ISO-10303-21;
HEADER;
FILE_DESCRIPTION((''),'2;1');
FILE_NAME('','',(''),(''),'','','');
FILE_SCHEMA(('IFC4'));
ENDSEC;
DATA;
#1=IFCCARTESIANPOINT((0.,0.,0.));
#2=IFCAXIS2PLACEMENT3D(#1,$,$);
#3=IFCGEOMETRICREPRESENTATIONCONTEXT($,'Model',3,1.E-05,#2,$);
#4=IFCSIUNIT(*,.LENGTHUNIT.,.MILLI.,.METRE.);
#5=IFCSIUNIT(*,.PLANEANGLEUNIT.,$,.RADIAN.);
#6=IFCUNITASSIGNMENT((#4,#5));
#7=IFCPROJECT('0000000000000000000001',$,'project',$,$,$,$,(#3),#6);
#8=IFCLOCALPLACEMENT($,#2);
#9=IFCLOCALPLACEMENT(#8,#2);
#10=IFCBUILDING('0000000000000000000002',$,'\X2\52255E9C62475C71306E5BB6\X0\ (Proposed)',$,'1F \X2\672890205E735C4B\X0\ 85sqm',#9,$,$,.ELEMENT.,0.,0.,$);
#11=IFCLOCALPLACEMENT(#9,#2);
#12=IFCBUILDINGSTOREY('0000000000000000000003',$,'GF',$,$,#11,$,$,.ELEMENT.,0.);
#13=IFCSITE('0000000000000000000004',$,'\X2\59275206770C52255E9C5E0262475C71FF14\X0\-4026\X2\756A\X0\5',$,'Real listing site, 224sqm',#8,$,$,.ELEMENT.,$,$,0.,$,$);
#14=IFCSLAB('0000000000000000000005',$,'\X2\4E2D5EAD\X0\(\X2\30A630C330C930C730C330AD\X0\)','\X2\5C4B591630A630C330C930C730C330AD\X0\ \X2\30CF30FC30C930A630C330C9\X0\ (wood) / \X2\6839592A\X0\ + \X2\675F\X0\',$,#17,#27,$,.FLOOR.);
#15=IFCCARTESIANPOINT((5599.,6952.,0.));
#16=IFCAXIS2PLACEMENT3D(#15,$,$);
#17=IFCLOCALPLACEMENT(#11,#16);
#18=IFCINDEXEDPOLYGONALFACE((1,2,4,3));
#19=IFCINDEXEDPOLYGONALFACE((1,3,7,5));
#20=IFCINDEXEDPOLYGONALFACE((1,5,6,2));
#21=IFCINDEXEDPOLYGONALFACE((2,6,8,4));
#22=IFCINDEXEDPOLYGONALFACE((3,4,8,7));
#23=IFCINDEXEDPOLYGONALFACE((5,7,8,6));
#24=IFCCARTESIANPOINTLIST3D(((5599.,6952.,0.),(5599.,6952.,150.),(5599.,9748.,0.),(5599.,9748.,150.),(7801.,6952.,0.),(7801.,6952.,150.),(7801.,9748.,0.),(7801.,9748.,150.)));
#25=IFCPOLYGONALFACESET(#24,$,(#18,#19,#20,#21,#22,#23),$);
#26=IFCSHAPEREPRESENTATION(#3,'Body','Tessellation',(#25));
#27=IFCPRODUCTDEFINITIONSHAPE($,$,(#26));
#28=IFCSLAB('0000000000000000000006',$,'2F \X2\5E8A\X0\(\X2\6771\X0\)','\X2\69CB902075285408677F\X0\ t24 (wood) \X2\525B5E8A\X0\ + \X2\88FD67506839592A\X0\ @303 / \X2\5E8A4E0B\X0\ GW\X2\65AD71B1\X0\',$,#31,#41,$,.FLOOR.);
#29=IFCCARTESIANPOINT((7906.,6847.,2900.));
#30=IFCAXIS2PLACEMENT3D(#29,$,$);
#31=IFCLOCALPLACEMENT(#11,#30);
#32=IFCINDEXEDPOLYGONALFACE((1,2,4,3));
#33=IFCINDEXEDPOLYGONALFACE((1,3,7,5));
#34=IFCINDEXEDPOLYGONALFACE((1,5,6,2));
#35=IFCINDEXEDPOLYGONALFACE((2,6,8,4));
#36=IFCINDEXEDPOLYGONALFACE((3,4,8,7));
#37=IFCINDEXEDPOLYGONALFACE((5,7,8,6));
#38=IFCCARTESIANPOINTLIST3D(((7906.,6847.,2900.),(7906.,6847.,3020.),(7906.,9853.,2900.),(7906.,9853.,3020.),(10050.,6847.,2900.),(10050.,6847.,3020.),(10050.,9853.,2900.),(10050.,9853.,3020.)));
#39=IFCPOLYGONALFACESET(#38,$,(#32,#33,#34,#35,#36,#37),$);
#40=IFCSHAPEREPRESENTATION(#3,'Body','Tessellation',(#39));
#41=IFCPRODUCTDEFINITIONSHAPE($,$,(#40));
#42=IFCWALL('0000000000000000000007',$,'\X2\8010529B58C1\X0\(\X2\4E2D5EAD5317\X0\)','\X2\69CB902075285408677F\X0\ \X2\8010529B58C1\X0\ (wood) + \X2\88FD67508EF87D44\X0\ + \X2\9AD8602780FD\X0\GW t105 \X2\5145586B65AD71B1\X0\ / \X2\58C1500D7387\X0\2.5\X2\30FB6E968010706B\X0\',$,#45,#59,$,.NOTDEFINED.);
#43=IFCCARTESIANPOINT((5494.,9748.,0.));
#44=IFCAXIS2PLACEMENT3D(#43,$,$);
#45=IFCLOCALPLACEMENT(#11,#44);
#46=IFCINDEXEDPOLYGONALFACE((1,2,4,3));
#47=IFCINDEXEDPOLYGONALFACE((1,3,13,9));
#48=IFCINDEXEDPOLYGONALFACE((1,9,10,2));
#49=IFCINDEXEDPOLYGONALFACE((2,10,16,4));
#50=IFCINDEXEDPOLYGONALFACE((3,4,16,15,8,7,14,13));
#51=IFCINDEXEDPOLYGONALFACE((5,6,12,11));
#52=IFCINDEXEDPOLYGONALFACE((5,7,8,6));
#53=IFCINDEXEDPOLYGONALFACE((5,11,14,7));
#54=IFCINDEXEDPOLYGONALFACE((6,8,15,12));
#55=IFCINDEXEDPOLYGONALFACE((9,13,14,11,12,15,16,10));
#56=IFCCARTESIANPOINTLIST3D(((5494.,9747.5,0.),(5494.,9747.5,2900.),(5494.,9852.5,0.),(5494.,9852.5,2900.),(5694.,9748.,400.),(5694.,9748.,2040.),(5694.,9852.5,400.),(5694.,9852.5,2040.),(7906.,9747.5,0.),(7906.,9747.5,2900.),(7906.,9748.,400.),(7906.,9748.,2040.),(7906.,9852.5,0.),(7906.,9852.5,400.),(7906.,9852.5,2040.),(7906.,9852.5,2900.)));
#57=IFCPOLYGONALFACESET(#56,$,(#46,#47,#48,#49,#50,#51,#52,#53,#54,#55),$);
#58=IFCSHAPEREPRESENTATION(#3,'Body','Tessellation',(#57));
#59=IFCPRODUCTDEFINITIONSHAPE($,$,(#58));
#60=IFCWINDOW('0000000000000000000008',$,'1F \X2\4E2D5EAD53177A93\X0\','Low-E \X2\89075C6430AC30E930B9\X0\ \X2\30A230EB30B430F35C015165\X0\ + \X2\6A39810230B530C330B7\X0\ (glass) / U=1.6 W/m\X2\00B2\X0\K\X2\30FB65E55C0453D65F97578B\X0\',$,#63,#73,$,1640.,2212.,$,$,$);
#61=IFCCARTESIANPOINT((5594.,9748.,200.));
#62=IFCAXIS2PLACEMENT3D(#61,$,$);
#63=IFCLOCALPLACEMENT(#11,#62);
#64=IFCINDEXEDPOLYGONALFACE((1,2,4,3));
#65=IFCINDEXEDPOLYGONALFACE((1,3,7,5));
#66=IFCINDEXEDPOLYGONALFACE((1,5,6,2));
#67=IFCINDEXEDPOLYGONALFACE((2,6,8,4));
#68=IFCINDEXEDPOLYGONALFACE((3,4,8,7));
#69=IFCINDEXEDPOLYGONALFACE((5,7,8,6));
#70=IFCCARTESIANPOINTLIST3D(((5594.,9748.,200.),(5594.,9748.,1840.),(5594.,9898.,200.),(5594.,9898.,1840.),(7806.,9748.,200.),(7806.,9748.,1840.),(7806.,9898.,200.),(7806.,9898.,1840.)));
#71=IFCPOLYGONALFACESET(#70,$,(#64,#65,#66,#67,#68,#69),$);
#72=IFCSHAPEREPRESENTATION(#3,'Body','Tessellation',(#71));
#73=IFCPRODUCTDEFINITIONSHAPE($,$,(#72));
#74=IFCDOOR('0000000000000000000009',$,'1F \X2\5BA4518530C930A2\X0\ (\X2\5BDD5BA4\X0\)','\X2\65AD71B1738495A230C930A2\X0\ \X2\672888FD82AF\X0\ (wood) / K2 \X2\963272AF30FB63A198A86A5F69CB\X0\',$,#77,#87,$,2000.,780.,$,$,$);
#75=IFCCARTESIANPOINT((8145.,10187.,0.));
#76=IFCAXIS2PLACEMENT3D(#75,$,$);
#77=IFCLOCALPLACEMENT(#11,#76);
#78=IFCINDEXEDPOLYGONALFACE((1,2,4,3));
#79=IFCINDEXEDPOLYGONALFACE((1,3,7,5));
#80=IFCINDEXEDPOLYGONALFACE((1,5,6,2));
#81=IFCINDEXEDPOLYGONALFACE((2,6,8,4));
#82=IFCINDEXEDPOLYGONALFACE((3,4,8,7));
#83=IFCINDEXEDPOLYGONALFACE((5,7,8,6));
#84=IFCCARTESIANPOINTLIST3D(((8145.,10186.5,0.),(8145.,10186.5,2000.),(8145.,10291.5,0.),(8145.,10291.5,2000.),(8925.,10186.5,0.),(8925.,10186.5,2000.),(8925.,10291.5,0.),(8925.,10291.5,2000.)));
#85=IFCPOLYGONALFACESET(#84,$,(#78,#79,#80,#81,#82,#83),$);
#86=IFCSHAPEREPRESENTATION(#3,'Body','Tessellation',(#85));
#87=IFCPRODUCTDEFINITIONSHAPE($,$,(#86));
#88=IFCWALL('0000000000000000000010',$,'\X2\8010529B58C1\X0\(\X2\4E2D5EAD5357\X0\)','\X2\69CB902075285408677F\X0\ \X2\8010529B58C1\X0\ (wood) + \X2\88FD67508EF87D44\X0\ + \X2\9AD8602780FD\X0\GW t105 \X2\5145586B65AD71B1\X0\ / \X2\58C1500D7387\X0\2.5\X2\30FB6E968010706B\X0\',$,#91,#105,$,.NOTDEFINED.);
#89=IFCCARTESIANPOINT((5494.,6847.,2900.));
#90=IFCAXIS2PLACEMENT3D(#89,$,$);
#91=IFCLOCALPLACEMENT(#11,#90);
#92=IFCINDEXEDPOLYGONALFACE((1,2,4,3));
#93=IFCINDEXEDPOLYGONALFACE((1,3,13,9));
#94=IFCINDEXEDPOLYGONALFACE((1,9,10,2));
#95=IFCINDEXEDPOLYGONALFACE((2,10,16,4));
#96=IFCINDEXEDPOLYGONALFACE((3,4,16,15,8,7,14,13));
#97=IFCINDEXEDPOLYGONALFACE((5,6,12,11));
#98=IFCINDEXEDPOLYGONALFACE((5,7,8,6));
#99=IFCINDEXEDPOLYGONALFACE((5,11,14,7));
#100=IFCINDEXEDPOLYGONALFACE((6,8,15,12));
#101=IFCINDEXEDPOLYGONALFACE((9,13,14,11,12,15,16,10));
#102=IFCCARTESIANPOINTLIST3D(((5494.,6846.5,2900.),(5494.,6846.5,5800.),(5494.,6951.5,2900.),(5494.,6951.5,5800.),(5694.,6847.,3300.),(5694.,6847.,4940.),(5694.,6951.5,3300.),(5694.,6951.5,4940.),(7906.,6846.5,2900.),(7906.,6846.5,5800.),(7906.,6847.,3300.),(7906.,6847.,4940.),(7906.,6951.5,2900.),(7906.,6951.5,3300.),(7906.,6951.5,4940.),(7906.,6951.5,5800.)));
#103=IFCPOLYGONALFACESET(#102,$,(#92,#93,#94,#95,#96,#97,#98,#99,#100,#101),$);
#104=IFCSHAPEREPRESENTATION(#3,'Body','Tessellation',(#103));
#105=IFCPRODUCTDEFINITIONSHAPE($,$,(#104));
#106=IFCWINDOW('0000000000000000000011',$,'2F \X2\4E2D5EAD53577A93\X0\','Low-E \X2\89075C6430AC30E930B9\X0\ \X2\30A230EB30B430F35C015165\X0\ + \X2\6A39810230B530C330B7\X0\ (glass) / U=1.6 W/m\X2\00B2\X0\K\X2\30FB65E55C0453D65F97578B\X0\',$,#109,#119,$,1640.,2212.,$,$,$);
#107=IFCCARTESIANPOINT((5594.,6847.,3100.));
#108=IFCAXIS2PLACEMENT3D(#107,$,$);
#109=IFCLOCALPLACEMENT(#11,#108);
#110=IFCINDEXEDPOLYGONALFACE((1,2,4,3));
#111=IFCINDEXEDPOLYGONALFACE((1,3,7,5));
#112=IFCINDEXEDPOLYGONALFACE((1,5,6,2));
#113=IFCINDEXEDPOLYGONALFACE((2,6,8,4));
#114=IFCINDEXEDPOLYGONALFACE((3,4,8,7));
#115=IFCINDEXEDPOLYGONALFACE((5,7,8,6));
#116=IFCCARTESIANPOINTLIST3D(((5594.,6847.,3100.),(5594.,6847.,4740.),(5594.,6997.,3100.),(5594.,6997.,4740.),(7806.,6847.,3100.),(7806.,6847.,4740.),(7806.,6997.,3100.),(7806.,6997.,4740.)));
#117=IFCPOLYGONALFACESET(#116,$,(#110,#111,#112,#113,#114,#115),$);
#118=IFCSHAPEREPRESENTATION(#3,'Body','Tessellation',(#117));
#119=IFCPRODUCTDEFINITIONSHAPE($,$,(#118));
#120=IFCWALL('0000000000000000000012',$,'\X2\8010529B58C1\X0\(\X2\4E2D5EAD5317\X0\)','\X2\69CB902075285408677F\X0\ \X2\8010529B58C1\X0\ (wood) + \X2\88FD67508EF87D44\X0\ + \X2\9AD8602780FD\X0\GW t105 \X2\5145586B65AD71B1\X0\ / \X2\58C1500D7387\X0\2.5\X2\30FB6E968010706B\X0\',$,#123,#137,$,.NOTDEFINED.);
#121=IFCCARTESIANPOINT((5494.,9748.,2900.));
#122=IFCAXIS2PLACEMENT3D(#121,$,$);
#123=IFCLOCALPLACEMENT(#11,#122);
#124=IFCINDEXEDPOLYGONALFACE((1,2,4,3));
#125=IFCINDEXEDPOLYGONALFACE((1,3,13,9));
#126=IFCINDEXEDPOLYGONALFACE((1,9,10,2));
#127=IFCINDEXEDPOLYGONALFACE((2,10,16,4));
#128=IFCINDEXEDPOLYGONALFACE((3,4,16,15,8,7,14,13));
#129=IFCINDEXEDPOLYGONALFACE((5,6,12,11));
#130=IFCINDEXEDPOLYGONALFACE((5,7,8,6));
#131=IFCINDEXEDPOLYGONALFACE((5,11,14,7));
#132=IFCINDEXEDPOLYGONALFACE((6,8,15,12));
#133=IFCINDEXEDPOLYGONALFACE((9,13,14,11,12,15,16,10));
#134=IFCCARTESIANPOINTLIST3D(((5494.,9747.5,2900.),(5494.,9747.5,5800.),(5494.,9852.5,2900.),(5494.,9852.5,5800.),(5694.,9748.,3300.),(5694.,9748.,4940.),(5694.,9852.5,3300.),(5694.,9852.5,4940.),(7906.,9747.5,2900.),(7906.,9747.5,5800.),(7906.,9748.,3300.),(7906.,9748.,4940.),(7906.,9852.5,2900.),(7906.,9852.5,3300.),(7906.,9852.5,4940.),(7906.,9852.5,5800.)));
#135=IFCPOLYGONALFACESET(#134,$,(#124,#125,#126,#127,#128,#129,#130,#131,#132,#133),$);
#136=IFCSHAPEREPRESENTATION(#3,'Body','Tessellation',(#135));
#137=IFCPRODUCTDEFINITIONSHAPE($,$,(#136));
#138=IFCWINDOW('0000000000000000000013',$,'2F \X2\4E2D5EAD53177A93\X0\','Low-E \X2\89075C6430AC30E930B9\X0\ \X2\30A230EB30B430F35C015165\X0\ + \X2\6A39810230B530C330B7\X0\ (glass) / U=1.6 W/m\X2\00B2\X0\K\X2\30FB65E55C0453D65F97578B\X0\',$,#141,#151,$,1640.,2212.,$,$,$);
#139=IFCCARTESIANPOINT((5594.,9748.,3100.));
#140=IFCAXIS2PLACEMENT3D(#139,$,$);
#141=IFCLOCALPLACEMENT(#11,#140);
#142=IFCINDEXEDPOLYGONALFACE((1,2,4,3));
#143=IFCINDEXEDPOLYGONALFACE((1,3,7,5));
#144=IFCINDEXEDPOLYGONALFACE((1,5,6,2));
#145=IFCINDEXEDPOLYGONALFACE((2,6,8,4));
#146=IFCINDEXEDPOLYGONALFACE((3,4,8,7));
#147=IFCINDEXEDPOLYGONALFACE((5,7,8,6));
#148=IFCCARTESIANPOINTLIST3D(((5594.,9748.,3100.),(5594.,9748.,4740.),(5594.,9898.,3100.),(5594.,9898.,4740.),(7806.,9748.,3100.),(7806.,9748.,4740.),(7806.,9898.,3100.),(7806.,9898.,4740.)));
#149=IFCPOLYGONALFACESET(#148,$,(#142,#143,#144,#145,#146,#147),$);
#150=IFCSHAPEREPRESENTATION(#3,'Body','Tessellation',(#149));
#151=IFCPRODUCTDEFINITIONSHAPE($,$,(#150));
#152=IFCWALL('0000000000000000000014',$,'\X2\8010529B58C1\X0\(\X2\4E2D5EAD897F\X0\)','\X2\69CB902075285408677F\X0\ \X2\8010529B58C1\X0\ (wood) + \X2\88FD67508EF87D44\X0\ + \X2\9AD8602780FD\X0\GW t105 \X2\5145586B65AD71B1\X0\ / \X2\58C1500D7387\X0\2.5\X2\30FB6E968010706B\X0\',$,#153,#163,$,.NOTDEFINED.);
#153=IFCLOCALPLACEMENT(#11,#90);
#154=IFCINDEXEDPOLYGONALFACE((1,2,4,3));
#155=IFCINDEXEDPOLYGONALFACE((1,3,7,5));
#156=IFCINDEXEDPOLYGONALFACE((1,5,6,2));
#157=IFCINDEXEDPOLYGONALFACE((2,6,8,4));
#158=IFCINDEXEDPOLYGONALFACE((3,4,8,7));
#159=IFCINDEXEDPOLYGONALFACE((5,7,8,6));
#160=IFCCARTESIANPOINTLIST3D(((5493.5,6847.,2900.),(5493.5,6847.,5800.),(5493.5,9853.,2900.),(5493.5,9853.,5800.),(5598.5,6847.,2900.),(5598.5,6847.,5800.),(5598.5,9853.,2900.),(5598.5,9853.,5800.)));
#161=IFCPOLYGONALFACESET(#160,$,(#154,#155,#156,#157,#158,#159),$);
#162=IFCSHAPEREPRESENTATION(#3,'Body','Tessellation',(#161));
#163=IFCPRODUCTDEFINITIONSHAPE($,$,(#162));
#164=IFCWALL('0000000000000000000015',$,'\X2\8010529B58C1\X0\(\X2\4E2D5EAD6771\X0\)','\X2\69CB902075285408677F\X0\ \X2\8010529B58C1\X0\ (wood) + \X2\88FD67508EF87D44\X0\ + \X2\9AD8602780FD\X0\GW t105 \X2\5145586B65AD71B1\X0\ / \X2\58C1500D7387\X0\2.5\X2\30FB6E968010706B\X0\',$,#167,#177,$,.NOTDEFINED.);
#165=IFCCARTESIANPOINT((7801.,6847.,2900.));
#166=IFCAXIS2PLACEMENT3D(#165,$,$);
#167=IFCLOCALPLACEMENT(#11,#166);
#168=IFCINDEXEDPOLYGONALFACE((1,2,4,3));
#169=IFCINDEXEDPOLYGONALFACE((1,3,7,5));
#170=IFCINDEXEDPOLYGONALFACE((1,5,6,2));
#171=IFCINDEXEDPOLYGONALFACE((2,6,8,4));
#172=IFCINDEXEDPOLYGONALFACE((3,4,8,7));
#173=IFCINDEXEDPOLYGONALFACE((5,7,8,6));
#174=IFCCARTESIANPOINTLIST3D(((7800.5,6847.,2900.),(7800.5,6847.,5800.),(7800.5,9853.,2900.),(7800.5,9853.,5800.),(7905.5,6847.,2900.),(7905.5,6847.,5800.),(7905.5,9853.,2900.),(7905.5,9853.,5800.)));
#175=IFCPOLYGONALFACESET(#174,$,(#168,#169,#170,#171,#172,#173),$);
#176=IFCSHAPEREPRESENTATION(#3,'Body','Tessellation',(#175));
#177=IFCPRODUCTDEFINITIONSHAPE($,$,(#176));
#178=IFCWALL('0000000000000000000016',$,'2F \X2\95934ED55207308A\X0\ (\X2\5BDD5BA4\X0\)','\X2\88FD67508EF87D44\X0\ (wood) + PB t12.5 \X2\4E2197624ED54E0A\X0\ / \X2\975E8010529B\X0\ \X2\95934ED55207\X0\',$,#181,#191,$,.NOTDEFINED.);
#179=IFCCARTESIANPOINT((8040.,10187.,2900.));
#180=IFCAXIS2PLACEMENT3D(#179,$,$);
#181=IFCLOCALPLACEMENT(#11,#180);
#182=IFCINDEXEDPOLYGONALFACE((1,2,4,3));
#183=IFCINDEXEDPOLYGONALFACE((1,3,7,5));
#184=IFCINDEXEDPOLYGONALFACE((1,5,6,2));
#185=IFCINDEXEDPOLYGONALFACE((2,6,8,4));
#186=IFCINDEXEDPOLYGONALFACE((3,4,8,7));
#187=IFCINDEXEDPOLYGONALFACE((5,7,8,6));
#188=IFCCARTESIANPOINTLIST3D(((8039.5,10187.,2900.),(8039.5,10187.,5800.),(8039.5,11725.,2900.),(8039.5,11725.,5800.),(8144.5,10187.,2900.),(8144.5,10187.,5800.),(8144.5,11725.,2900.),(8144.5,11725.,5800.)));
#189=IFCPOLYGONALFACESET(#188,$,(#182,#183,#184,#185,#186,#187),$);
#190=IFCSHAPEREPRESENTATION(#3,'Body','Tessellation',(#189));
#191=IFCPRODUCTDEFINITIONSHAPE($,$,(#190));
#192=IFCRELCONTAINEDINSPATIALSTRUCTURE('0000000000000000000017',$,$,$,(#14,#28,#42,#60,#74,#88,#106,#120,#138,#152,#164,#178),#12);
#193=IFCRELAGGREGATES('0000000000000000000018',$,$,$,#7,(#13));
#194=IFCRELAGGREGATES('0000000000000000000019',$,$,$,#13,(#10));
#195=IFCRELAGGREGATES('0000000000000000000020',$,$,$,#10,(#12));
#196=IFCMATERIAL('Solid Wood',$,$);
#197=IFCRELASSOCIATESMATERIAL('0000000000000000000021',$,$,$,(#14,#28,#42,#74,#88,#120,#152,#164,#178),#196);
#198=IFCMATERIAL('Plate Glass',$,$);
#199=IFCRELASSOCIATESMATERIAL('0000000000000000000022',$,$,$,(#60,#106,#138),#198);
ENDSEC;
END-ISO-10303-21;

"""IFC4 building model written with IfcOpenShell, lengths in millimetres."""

from ifc_helpers import new_model, si_unit, frame, frame_2d, origin, place, context, project, spatial, rectangle, extrude, material, element, fill, save


model = new_model("IFC4")

# Units and contexts
model_context = context("Model", 3, precision=1e-05, world=origin())
ifc_project = project(units=[si_unit("LENGTHUNIT", "METRE", prefix="MILLI"), si_unit("PLANEANGLEUNIT", "RADIAN")], contexts=[model_context])

# Site, building, storey
site_placement = place(None, origin())
site = spatial("IfcSite", under=ifc_project, at=site_placement, Name="大分県別府市扇山４-4026番5", ObjectType="Real listing site, 224sqm", CompositionType="ELEMENT", RefElevation=0.0)
building_placement = place(site_placement, origin())
building = spatial("IfcBuilding", under=site, at=building_placement, Name="別府扇山の家 (Proposed)", ObjectType="1F 木造平屋 85sqm", CompositionType="ELEMENT", ElevationOfRefHeight=0.0, ElevationOfTerrain=0.0)
storey_placement = place(building_placement, origin())
storey = spatial("IfcBuildingStorey", under=building, at=storey_placement, Name="GF", CompositionType="ELEMENT", Elevation=0.0)

# Slabs
ifc_material_1 = material(Name="Solid Wood")
slab_1_placement = place(storey_placement, frame((5599.0, 6952.0, 0.0)))
element("IfcSlab", 1, at=slab_1_placement, inside=storey, material=ifc_material_1, Name="中庭(ウッドデッキ)", Description="屋外ウッドデッキ ハードウッド (wood) / 根太 + 束", PredefinedType="FLOOR", context=model_context, shape_type="SweptSolid", body=[
    extrude(rectangle(XDim=2202.0, YDim=2796.0, at=frame_2d((1101.0, 1398.0))), frame((5599.0, 6952.0, 0.0)), (0.0, 0.0, 1.0), 150.0),
])
slab_2_placement = place(storey_placement, frame((7906.0, 6847.0, 2900.0)))
element("IfcSlab", 2, at=slab_2_placement, inside=storey, material=ifc_material_1, Name="2F 床(東)", Description="構造用合板 t24 (wood) 剛床 + 製材根太 @303 / 床下 GW断熱", PredefinedType="FLOOR", context=model_context, shape_type="SweptSolid", body=[
    extrude(rectangle(XDim=2144.0, YDim=3006.0, at=frame_2d((1072.0, 1503.0))), frame((7906.0, 6847.0, 2900.0)), (0.0, 0.0, 1.0), 120.0),
])

# Wall, opening, window
wall_1_placement = place(storey_placement, frame((5494.0, 9748.0, 0.0)))
wall_1 = element("IfcWall", 3, at=wall_1_placement, inside=storey, material=ifc_material_1, Name="耐力壁(中庭北)", Description="構造用合板 耐力壁 (wood) + 製材軸組 + 高性能GW t105 充填断熱 / 壁倍率2.5・準耐火", PredefinedType="NOTDEFINED", context=model_context, shape_type="SweptSolid", body=[
    extrude(rectangle(XDim=2412.0, YDim=105.0, at=frame_2d((1206.0, 52.0))), frame((5494.0, 9748.0, 0.0)), (0.0, 0.0, 1.0), 2900.0),
])
opening_1_placement = place(storey_placement, frame((5594.0, 9748.0, 200.0)))
opening_1 = element("IfcOpeningElement", 4, at=opening_1_placement, cuts=wall_1, PredefinedType="NOTDEFINED", context=model_context, shape_type="SweptSolid", body=[
    extrude(rectangle(XDim=2212.0, YDim=150.0, at=frame_2d((1106.0, 75.0))), frame((5594.0, 9748.0, 200.0)), (0.0, 0.0, 1.0), 1640.0),
])
ifc_material_2 = material(Name="Plate Glass")
window_1_placement = place(storey_placement, frame((5594.0, 9748.0, 200.0)))
window_1 = element("IfcWindow", 5, at=window_1_placement, inside=storey, material=ifc_material_2, Name="1F 中庭北窓", Description="Low-E 複層ガラス アルゴン封入 + 樹脂サッシ (glass) / U=1.6 W/m²K・日射取得型", OverallHeight=1640.0, OverallWidth=2212.0, context=model_context, shape_type="SweptSolid", body=[
    extrude(rectangle(XDim=2212.0, YDim=150.0, at=frame_2d((1106.0, 75.0))), frame((5594.0, 9748.0, 200.0)), (0.0, 0.0, 1.0), 1640.0),
])
fill(opening_1, window_1)

# Door
door_1_placement = place(storey_placement, frame((8145.0, 10187.0, 0.0)))
element("IfcDoor", 6, at=door_1_placement, inside=storey, material=ifc_material_1, Name="1F 室内ドア (寝室)", Description="断熱玄関ドア 木製芯 (wood) / K2 防犯・採風機構", OverallHeight=2000.0, OverallWidth=780.0, context=model_context, shape_type="SweptSolid", body=[
    extrude(rectangle(XDim=780.0, YDim=105.0, at=frame_2d((390.0, 52.0))), frame((8145.0, 10187.0, 0.0)), (0.0, 0.0, 1.0), 2000.0),
])

# Walls, openings, windows
wall_2_placement = place(storey_placement, frame((5494.0, 6847.0, 2900.0)))
wall_2 = element("IfcWall", 7, at=wall_2_placement, inside=storey, material=ifc_material_1, Name="耐力壁(中庭南)", Description="構造用合板 耐力壁 (wood) + 製材軸組 + 高性能GW t105 充填断熱 / 壁倍率2.5・準耐火", PredefinedType="NOTDEFINED", context=model_context, shape_type="SweptSolid", body=[
    extrude(rectangle(XDim=2412.0, YDim=105.0, at=frame_2d((1206.0, 52.0))), frame((5494.0, 6847.0, 2900.0)), (0.0, 0.0, 1.0), 2900.0),
])
opening_2_placement = place(storey_placement, frame((5594.0, 6847.0, 3100.0)))
opening_2 = element("IfcOpeningElement", 8, at=opening_2_placement, cuts=wall_2, PredefinedType="NOTDEFINED", context=model_context, shape_type="SweptSolid", body=[
    extrude(rectangle(XDim=2212.0, YDim=150.0, at=frame_2d((1106.0, 75.0))), frame((5594.0, 6847.0, 3100.0)), (0.0, 0.0, 1.0), 1640.0),
])
window_2_placement = place(storey_placement, frame((5594.0, 6847.0, 3100.0)))
window_2 = element("IfcWindow", 9, at=window_2_placement, inside=storey, material=ifc_material_2, Name="2F 中庭南窓", Description="Low-E 複層ガラス アルゴン封入 + 樹脂サッシ (glass) / U=1.6 W/m²K・日射取得型", OverallHeight=1640.0, OverallWidth=2212.0, context=model_context, shape_type="SweptSolid", body=[
    extrude(rectangle(XDim=2212.0, YDim=150.0, at=frame_2d((1106.0, 75.0))), frame((5594.0, 6847.0, 3100.0)), (0.0, 0.0, 1.0), 1640.0),
])
fill(opening_2, window_2)
wall_3_placement = place(storey_placement, frame((5494.0, 9748.0, 2900.0)))
wall_3 = element("IfcWall", 10, at=wall_3_placement, inside=storey, material=ifc_material_1, Name="耐力壁(中庭北)", Description="構造用合板 耐力壁 (wood) + 製材軸組 + 高性能GW t105 充填断熱 / 壁倍率2.5・準耐火", PredefinedType="NOTDEFINED", context=model_context, shape_type="SweptSolid", body=[
    extrude(rectangle(XDim=2412.0, YDim=105.0, at=frame_2d((1206.0, 52.0))), frame((5494.0, 9748.0, 2900.0)), (0.0, 0.0, 1.0), 2900.0),
])
opening_3_placement = place(storey_placement, frame((5594.0, 9748.0, 3100.0)))
opening_3 = element("IfcOpeningElement", 11, at=opening_3_placement, cuts=wall_3, PredefinedType="NOTDEFINED", context=model_context, shape_type="SweptSolid", body=[
    extrude(rectangle(XDim=2212.0, YDim=150.0, at=frame_2d((1106.0, 75.0))), frame((5594.0, 9748.0, 3100.0)), (0.0, 0.0, 1.0), 1640.0),
])
window_3_placement = place(storey_placement, frame((5594.0, 9748.0, 3100.0)))
window_3 = element("IfcWindow", 12, at=window_3_placement, inside=storey, material=ifc_material_2, Name="2F 中庭北窓", Description="Low-E 複層ガラス アルゴン封入 + 樹脂サッシ (glass) / U=1.6 W/m²K・日射取得型", OverallHeight=1640.0, OverallWidth=2212.0, context=model_context, shape_type="SweptSolid", body=[
    extrude(rectangle(XDim=2212.0, YDim=150.0, at=frame_2d((1106.0, 75.0))), frame((5594.0, 9748.0, 3100.0)), (0.0, 0.0, 1.0), 1640.0),
])
fill(opening_3, window_3)

# Walls
wall_4_placement = place(storey_placement, frame((5494.0, 6847.0, 2900.0)))
element("IfcWall", 13, at=wall_4_placement, inside=storey, material=ifc_material_1, Name="耐力壁(中庭西)", Description="構造用合板 耐力壁 (wood) + 製材軸組 + 高性能GW t105 充填断熱 / 壁倍率2.5・準耐火", PredefinedType="NOTDEFINED", context=model_context, shape_type="SweptSolid", body=[
    extrude(rectangle(XDim=105.0, YDim=3006.0, at=frame_2d((52.0, 1503.0))), frame((5494.0, 6847.0, 2900.0)), (0.0, 0.0, 1.0), 2900.0),
])
wall_5_placement = place(storey_placement, frame((7801.0, 6847.0, 2900.0)))
element("IfcWall", 14, at=wall_5_placement, inside=storey, material=ifc_material_1, Name="耐力壁(中庭東)", Description="構造用合板 耐力壁 (wood) + 製材軸組 + 高性能GW t105 充填断熱 / 壁倍率2.5・準耐火", PredefinedType="NOTDEFINED", context=model_context, shape_type="SweptSolid", body=[
    extrude(rectangle(XDim=105.0, YDim=3006.0, at=frame_2d((52.0, 1503.0))), frame((7801.0, 6847.0, 2900.0)), (0.0, 0.0, 1.0), 2900.0),
])
wall_6_placement = place(storey_placement, frame((8040.0, 10187.0, 2900.0)))
element("IfcWall", 15, at=wall_6_placement, inside=storey, material=ifc_material_1, Name="2F 間仕切り (寝室)", Description="製材軸組 (wood) + PB t12.5 両面仕上 / 非耐力 間仕切", PredefinedType="NOTDEFINED", context=model_context, shape_type="SweptSolid", body=[
    extrude(rectangle(XDim=105.0, YDim=1538.0, at=frame_2d((52.0, 769.0))), frame((8040.0, 10187.0, 2900.0)), (0.0, 0.0, 1.0), 2900.0),
])

save(model, "model.ifc")
